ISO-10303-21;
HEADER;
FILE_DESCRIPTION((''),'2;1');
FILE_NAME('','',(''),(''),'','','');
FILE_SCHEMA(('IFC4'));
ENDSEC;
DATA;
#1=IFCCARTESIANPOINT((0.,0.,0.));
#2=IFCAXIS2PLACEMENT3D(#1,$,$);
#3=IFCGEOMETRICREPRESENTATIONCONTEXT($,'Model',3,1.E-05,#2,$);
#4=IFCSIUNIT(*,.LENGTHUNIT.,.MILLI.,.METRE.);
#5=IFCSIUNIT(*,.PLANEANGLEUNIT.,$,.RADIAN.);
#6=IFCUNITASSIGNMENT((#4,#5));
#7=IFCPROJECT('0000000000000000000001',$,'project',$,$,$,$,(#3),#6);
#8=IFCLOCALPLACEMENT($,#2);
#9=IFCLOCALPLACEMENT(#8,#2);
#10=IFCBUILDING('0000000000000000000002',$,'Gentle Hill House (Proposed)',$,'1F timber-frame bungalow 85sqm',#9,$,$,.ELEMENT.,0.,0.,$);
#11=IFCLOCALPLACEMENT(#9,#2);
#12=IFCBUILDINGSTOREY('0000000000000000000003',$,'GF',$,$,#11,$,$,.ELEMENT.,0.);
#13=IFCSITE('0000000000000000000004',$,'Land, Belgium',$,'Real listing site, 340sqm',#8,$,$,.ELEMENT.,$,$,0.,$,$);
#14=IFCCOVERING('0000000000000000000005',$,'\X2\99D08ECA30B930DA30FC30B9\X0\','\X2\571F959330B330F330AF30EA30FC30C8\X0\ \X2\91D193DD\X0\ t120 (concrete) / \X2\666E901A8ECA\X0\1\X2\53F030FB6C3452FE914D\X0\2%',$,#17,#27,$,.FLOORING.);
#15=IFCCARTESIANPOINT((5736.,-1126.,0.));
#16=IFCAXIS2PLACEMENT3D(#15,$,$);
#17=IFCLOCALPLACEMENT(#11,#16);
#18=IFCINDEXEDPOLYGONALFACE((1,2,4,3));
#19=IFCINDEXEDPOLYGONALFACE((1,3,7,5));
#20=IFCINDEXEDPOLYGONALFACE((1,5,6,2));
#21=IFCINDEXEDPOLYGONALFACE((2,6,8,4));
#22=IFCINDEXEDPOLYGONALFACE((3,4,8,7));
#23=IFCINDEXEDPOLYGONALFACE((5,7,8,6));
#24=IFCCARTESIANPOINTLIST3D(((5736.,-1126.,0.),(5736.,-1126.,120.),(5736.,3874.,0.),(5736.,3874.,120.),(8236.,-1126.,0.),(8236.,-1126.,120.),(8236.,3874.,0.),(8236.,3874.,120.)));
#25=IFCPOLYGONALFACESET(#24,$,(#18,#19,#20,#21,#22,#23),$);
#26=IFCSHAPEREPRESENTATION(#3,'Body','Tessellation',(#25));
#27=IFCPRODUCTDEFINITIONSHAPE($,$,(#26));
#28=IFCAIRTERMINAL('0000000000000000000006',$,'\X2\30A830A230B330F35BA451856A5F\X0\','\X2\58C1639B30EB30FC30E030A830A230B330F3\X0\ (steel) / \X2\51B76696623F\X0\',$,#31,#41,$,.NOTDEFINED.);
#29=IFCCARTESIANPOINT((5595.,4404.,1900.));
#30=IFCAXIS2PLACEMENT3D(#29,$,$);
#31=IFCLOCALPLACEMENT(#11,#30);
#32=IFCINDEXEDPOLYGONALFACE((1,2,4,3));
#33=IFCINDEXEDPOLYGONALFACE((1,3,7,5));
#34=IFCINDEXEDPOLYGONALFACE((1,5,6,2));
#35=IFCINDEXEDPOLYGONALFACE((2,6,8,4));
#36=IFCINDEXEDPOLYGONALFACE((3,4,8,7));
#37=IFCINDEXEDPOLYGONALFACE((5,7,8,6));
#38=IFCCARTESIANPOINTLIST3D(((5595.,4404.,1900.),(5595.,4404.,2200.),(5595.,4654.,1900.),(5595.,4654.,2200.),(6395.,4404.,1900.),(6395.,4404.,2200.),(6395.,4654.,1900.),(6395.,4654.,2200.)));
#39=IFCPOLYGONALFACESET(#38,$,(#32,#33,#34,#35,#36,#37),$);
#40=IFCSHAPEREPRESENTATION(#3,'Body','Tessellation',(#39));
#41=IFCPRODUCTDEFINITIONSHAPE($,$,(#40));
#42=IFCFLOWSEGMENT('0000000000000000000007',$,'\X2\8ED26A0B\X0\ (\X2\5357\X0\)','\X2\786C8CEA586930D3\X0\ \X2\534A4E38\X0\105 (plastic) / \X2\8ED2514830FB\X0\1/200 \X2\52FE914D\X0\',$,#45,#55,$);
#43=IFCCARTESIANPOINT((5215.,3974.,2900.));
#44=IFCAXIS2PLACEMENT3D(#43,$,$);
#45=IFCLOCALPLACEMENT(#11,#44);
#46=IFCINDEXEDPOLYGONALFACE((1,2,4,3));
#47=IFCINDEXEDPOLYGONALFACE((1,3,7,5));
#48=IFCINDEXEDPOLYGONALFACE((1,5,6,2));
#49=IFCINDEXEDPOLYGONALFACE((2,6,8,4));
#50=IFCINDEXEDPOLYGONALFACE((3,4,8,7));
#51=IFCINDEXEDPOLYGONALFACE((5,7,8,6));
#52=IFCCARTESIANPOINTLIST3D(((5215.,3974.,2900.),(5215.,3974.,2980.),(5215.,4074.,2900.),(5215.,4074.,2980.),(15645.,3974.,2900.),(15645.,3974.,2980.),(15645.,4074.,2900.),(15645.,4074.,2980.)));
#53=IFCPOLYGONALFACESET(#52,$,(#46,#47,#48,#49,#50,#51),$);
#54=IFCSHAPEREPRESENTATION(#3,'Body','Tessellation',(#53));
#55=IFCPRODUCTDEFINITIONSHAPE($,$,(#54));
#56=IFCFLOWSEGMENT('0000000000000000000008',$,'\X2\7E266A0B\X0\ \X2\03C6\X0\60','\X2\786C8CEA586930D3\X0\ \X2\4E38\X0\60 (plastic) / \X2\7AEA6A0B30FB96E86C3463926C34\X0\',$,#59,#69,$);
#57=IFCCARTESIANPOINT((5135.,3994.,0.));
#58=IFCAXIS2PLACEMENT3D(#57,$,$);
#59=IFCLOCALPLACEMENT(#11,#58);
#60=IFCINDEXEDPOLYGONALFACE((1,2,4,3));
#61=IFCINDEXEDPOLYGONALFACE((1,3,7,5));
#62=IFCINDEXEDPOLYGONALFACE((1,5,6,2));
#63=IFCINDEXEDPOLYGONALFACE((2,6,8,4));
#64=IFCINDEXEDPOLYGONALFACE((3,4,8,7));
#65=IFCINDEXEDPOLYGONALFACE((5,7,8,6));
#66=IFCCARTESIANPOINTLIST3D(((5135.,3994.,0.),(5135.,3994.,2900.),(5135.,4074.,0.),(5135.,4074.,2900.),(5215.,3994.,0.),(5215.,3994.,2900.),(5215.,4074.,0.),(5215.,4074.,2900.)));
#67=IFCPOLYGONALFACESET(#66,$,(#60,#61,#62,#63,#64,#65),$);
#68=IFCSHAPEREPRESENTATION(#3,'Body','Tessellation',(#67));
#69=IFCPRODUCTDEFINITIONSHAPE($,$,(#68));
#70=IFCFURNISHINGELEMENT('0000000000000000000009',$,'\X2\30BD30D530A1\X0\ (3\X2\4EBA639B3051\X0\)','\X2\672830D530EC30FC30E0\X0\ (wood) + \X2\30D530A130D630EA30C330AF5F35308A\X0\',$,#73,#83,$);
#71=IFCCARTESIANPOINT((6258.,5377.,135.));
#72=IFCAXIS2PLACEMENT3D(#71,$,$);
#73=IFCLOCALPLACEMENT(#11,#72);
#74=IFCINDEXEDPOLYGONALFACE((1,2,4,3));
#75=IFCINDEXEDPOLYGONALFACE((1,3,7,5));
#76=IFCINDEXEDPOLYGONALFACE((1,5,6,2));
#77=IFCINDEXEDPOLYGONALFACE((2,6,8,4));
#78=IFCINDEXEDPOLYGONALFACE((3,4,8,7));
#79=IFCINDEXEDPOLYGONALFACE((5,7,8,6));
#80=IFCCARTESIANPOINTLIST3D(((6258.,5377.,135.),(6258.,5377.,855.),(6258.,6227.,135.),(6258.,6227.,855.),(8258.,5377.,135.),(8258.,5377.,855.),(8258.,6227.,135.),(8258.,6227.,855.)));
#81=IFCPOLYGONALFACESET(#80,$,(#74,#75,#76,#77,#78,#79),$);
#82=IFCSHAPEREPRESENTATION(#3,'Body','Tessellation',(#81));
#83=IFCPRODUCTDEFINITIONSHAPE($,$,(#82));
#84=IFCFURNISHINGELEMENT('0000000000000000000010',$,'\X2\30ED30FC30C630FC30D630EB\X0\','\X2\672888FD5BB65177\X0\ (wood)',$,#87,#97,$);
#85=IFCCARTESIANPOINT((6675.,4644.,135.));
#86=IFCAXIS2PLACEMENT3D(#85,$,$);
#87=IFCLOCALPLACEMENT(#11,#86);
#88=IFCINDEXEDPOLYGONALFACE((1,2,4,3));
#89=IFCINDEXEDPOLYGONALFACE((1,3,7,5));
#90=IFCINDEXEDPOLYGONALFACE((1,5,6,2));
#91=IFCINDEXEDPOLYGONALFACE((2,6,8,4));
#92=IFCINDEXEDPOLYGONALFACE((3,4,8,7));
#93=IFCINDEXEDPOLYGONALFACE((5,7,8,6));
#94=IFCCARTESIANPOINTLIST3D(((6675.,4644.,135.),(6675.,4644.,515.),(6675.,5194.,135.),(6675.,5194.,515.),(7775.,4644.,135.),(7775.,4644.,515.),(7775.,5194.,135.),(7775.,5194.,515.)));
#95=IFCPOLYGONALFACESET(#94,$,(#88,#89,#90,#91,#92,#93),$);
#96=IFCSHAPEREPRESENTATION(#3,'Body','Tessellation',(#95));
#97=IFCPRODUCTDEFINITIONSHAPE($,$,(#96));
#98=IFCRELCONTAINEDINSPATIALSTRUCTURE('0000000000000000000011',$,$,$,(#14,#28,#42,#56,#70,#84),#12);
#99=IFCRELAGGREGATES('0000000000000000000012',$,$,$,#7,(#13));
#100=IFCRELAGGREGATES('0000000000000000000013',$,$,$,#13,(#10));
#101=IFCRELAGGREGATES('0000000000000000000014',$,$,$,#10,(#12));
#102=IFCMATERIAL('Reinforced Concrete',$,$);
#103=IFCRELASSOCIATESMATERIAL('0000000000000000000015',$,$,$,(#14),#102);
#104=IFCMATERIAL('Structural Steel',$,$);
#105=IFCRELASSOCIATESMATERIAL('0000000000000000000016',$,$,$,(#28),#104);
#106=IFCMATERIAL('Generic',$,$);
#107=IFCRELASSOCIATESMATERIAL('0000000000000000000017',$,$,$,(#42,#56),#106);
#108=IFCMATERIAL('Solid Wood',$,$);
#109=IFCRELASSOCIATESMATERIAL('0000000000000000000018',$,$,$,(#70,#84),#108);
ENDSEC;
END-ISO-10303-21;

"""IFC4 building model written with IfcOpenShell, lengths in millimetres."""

from ifc_helpers import new_model, si_unit, frame, frame_2d, origin, place, context, project, spatial, rectangle, extrude, material, element, save


model = new_model("IFC4")

# Units and contexts
model_context = context("Model", 3, precision=1e-05, world=origin())
ifc_project = project(units=[si_unit("LENGTHUNIT", "METRE", prefix="MILLI"), si_unit("PLANEANGLEUNIT", "RADIAN")], contexts=[model_context])

# Site, building, storey
site_placement = place(None, origin())
site = spatial("IfcSite", under=ifc_project, at=site_placement, Name="Land, Belgium", ObjectType="Real listing site, 340sqm", CompositionType="ELEMENT", RefElevation=0.0)
building_placement = place(site_placement, origin())
building = spatial("IfcBuilding", under=site, at=building_placement, Name="Gentle Hill House (Proposed)", ObjectType="1F timber-frame bungalow 85sqm", CompositionType="ELEMENT", ElevationOfRefHeight=0.0, ElevationOfTerrain=0.0)
storey_placement = place(building_placement, origin())
storey = spatial("IfcBuildingStorey", under=building, at=storey_placement, Name="GF", CompositionType="ELEMENT", Elevation=0.0)

# Shared definitions
ifc_material_1 = material(Name="Solid Wood")

# Shared definitions
ifc_material_2 = material(Name="Reinforced Concrete")

# Shared definitions
ifc_material_3 = material(Name="Structural Steel")

# Covering
ifc_material_4 = material(Name="Generic")
covering_1_placement = place(storey_placement, frame((5736.0, -1126.0, 0.0)))
element("IfcCovering", 1, at=covering_1_placement, inside=storey, material=ifc_material_2, Name="駐車スペース", Description="土間コンクリート 金鏝 t120 (concrete) / 普通車1台・水勾配2%", PredefinedType="FLOORING", context=model_context, shape_type="SweptSolid", body=[
    extrude(rectangle(XDim=2500.0, YDim=5000.0, at=frame_2d((1250.0, 2500.0))), frame((5736.0, -1126.0, 0.0)), (0.0, 0.0, 1.0), 120.0),
])

# Air terminal
air_terminal_placement = place(storey_placement, frame((5595.0, 4404.0, 1900.0)))
element("IfcAirTerminal", 2, at=air_terminal_placement, inside=storey, material=ifc_material_3, Name="エアコン室内機", Description="壁掛ルームエアコン (steel) / 冷暖房", PredefinedType="NOTDEFINED", context=model_context, shape_type="SweptSolid", body=[
    extrude(rectangle(XDim=800.0, YDim=250.0, at=frame_2d((400.0, 125.0))), frame((5595.0, 4404.0, 1900.0)), (0.0, 0.0, 1.0), 300.0),
])

# Flow segments
flow_segment_1_placement = place(storey_placement, frame((5215.0, 3974.0, 2900.0)))
element("IfcFlowSegment", 3, at=flow_segment_1_placement, inside=storey, material=ifc_material_4, Name="軒樋 (南)", Description="硬質塩ビ 半丸105 (plastic) / 軒先・1/200 勾配", context=model_context, shape_type="SweptSolid", body=[
    extrude(rectangle(XDim=10430.0, YDim=100.0, at=frame_2d((5215.0, 50.0))), frame((5215.0, 3974.0, 2900.0)), (0.0, 0.0, 1.0), 80.0),
])
flow_segment_2_placement = place(storey_placement, frame((5135.0, 3994.0, 0.0)))
element("IfcFlowSegment", 4, at=flow_segment_2_placement, inside=storey, material=ifc_material_4, Name="縦樋 φ60", Description="硬質塩ビ 丸60 (plastic) / 竪樋・雨水排水", context=model_context, shape_type="SweptSolid", body=[
    extrude(rectangle(XDim=80.0, YDim=80.0, at=frame_2d((40.0, 40.0))), frame((5135.0, 3994.0, 0.0)), (0.0, 0.0, 1.0), 2900.0),
])

# Furnishing elements
furnishing_1_placement = place(storey_placement, frame((6258.0, 5377.0, 135.0)))
element("IfcFurnishingElement", 5, at=furnishing_1_placement, inside=storey, material=ifc_material_1, Name="ソファ (3人掛け)", Description="木フレーム (wood) + ファブリック張り", context=model_context, shape_type="SweptSolid", body=[
    extrude(rectangle(XDim=2000.0, YDim=850.0, at=frame_2d((1000.0, 425.0))), frame((6258.0, 5377.0, 135.0)), (0.0, 0.0, 1.0), 720.0),
])
furnishing_2_placement = place(storey_placement, frame((6675.0, 4644.0, 135.0)))
element("IfcFurnishingElement", 6, at=furnishing_2_placement, inside=storey, material=ifc_material_1, Name="ローテーブル", Description="木製家具 (wood)", context=model_context, shape_type="SweptSolid", body=[
    extrude(rectangle(XDim=1100.0, YDim=550.0, at=frame_2d((550.0, 275.0))), frame((6675.0, 4644.0, 135.0)), (0.0, 0.0, 1.0), 380.0),
])

save(model, "model.ifc")
